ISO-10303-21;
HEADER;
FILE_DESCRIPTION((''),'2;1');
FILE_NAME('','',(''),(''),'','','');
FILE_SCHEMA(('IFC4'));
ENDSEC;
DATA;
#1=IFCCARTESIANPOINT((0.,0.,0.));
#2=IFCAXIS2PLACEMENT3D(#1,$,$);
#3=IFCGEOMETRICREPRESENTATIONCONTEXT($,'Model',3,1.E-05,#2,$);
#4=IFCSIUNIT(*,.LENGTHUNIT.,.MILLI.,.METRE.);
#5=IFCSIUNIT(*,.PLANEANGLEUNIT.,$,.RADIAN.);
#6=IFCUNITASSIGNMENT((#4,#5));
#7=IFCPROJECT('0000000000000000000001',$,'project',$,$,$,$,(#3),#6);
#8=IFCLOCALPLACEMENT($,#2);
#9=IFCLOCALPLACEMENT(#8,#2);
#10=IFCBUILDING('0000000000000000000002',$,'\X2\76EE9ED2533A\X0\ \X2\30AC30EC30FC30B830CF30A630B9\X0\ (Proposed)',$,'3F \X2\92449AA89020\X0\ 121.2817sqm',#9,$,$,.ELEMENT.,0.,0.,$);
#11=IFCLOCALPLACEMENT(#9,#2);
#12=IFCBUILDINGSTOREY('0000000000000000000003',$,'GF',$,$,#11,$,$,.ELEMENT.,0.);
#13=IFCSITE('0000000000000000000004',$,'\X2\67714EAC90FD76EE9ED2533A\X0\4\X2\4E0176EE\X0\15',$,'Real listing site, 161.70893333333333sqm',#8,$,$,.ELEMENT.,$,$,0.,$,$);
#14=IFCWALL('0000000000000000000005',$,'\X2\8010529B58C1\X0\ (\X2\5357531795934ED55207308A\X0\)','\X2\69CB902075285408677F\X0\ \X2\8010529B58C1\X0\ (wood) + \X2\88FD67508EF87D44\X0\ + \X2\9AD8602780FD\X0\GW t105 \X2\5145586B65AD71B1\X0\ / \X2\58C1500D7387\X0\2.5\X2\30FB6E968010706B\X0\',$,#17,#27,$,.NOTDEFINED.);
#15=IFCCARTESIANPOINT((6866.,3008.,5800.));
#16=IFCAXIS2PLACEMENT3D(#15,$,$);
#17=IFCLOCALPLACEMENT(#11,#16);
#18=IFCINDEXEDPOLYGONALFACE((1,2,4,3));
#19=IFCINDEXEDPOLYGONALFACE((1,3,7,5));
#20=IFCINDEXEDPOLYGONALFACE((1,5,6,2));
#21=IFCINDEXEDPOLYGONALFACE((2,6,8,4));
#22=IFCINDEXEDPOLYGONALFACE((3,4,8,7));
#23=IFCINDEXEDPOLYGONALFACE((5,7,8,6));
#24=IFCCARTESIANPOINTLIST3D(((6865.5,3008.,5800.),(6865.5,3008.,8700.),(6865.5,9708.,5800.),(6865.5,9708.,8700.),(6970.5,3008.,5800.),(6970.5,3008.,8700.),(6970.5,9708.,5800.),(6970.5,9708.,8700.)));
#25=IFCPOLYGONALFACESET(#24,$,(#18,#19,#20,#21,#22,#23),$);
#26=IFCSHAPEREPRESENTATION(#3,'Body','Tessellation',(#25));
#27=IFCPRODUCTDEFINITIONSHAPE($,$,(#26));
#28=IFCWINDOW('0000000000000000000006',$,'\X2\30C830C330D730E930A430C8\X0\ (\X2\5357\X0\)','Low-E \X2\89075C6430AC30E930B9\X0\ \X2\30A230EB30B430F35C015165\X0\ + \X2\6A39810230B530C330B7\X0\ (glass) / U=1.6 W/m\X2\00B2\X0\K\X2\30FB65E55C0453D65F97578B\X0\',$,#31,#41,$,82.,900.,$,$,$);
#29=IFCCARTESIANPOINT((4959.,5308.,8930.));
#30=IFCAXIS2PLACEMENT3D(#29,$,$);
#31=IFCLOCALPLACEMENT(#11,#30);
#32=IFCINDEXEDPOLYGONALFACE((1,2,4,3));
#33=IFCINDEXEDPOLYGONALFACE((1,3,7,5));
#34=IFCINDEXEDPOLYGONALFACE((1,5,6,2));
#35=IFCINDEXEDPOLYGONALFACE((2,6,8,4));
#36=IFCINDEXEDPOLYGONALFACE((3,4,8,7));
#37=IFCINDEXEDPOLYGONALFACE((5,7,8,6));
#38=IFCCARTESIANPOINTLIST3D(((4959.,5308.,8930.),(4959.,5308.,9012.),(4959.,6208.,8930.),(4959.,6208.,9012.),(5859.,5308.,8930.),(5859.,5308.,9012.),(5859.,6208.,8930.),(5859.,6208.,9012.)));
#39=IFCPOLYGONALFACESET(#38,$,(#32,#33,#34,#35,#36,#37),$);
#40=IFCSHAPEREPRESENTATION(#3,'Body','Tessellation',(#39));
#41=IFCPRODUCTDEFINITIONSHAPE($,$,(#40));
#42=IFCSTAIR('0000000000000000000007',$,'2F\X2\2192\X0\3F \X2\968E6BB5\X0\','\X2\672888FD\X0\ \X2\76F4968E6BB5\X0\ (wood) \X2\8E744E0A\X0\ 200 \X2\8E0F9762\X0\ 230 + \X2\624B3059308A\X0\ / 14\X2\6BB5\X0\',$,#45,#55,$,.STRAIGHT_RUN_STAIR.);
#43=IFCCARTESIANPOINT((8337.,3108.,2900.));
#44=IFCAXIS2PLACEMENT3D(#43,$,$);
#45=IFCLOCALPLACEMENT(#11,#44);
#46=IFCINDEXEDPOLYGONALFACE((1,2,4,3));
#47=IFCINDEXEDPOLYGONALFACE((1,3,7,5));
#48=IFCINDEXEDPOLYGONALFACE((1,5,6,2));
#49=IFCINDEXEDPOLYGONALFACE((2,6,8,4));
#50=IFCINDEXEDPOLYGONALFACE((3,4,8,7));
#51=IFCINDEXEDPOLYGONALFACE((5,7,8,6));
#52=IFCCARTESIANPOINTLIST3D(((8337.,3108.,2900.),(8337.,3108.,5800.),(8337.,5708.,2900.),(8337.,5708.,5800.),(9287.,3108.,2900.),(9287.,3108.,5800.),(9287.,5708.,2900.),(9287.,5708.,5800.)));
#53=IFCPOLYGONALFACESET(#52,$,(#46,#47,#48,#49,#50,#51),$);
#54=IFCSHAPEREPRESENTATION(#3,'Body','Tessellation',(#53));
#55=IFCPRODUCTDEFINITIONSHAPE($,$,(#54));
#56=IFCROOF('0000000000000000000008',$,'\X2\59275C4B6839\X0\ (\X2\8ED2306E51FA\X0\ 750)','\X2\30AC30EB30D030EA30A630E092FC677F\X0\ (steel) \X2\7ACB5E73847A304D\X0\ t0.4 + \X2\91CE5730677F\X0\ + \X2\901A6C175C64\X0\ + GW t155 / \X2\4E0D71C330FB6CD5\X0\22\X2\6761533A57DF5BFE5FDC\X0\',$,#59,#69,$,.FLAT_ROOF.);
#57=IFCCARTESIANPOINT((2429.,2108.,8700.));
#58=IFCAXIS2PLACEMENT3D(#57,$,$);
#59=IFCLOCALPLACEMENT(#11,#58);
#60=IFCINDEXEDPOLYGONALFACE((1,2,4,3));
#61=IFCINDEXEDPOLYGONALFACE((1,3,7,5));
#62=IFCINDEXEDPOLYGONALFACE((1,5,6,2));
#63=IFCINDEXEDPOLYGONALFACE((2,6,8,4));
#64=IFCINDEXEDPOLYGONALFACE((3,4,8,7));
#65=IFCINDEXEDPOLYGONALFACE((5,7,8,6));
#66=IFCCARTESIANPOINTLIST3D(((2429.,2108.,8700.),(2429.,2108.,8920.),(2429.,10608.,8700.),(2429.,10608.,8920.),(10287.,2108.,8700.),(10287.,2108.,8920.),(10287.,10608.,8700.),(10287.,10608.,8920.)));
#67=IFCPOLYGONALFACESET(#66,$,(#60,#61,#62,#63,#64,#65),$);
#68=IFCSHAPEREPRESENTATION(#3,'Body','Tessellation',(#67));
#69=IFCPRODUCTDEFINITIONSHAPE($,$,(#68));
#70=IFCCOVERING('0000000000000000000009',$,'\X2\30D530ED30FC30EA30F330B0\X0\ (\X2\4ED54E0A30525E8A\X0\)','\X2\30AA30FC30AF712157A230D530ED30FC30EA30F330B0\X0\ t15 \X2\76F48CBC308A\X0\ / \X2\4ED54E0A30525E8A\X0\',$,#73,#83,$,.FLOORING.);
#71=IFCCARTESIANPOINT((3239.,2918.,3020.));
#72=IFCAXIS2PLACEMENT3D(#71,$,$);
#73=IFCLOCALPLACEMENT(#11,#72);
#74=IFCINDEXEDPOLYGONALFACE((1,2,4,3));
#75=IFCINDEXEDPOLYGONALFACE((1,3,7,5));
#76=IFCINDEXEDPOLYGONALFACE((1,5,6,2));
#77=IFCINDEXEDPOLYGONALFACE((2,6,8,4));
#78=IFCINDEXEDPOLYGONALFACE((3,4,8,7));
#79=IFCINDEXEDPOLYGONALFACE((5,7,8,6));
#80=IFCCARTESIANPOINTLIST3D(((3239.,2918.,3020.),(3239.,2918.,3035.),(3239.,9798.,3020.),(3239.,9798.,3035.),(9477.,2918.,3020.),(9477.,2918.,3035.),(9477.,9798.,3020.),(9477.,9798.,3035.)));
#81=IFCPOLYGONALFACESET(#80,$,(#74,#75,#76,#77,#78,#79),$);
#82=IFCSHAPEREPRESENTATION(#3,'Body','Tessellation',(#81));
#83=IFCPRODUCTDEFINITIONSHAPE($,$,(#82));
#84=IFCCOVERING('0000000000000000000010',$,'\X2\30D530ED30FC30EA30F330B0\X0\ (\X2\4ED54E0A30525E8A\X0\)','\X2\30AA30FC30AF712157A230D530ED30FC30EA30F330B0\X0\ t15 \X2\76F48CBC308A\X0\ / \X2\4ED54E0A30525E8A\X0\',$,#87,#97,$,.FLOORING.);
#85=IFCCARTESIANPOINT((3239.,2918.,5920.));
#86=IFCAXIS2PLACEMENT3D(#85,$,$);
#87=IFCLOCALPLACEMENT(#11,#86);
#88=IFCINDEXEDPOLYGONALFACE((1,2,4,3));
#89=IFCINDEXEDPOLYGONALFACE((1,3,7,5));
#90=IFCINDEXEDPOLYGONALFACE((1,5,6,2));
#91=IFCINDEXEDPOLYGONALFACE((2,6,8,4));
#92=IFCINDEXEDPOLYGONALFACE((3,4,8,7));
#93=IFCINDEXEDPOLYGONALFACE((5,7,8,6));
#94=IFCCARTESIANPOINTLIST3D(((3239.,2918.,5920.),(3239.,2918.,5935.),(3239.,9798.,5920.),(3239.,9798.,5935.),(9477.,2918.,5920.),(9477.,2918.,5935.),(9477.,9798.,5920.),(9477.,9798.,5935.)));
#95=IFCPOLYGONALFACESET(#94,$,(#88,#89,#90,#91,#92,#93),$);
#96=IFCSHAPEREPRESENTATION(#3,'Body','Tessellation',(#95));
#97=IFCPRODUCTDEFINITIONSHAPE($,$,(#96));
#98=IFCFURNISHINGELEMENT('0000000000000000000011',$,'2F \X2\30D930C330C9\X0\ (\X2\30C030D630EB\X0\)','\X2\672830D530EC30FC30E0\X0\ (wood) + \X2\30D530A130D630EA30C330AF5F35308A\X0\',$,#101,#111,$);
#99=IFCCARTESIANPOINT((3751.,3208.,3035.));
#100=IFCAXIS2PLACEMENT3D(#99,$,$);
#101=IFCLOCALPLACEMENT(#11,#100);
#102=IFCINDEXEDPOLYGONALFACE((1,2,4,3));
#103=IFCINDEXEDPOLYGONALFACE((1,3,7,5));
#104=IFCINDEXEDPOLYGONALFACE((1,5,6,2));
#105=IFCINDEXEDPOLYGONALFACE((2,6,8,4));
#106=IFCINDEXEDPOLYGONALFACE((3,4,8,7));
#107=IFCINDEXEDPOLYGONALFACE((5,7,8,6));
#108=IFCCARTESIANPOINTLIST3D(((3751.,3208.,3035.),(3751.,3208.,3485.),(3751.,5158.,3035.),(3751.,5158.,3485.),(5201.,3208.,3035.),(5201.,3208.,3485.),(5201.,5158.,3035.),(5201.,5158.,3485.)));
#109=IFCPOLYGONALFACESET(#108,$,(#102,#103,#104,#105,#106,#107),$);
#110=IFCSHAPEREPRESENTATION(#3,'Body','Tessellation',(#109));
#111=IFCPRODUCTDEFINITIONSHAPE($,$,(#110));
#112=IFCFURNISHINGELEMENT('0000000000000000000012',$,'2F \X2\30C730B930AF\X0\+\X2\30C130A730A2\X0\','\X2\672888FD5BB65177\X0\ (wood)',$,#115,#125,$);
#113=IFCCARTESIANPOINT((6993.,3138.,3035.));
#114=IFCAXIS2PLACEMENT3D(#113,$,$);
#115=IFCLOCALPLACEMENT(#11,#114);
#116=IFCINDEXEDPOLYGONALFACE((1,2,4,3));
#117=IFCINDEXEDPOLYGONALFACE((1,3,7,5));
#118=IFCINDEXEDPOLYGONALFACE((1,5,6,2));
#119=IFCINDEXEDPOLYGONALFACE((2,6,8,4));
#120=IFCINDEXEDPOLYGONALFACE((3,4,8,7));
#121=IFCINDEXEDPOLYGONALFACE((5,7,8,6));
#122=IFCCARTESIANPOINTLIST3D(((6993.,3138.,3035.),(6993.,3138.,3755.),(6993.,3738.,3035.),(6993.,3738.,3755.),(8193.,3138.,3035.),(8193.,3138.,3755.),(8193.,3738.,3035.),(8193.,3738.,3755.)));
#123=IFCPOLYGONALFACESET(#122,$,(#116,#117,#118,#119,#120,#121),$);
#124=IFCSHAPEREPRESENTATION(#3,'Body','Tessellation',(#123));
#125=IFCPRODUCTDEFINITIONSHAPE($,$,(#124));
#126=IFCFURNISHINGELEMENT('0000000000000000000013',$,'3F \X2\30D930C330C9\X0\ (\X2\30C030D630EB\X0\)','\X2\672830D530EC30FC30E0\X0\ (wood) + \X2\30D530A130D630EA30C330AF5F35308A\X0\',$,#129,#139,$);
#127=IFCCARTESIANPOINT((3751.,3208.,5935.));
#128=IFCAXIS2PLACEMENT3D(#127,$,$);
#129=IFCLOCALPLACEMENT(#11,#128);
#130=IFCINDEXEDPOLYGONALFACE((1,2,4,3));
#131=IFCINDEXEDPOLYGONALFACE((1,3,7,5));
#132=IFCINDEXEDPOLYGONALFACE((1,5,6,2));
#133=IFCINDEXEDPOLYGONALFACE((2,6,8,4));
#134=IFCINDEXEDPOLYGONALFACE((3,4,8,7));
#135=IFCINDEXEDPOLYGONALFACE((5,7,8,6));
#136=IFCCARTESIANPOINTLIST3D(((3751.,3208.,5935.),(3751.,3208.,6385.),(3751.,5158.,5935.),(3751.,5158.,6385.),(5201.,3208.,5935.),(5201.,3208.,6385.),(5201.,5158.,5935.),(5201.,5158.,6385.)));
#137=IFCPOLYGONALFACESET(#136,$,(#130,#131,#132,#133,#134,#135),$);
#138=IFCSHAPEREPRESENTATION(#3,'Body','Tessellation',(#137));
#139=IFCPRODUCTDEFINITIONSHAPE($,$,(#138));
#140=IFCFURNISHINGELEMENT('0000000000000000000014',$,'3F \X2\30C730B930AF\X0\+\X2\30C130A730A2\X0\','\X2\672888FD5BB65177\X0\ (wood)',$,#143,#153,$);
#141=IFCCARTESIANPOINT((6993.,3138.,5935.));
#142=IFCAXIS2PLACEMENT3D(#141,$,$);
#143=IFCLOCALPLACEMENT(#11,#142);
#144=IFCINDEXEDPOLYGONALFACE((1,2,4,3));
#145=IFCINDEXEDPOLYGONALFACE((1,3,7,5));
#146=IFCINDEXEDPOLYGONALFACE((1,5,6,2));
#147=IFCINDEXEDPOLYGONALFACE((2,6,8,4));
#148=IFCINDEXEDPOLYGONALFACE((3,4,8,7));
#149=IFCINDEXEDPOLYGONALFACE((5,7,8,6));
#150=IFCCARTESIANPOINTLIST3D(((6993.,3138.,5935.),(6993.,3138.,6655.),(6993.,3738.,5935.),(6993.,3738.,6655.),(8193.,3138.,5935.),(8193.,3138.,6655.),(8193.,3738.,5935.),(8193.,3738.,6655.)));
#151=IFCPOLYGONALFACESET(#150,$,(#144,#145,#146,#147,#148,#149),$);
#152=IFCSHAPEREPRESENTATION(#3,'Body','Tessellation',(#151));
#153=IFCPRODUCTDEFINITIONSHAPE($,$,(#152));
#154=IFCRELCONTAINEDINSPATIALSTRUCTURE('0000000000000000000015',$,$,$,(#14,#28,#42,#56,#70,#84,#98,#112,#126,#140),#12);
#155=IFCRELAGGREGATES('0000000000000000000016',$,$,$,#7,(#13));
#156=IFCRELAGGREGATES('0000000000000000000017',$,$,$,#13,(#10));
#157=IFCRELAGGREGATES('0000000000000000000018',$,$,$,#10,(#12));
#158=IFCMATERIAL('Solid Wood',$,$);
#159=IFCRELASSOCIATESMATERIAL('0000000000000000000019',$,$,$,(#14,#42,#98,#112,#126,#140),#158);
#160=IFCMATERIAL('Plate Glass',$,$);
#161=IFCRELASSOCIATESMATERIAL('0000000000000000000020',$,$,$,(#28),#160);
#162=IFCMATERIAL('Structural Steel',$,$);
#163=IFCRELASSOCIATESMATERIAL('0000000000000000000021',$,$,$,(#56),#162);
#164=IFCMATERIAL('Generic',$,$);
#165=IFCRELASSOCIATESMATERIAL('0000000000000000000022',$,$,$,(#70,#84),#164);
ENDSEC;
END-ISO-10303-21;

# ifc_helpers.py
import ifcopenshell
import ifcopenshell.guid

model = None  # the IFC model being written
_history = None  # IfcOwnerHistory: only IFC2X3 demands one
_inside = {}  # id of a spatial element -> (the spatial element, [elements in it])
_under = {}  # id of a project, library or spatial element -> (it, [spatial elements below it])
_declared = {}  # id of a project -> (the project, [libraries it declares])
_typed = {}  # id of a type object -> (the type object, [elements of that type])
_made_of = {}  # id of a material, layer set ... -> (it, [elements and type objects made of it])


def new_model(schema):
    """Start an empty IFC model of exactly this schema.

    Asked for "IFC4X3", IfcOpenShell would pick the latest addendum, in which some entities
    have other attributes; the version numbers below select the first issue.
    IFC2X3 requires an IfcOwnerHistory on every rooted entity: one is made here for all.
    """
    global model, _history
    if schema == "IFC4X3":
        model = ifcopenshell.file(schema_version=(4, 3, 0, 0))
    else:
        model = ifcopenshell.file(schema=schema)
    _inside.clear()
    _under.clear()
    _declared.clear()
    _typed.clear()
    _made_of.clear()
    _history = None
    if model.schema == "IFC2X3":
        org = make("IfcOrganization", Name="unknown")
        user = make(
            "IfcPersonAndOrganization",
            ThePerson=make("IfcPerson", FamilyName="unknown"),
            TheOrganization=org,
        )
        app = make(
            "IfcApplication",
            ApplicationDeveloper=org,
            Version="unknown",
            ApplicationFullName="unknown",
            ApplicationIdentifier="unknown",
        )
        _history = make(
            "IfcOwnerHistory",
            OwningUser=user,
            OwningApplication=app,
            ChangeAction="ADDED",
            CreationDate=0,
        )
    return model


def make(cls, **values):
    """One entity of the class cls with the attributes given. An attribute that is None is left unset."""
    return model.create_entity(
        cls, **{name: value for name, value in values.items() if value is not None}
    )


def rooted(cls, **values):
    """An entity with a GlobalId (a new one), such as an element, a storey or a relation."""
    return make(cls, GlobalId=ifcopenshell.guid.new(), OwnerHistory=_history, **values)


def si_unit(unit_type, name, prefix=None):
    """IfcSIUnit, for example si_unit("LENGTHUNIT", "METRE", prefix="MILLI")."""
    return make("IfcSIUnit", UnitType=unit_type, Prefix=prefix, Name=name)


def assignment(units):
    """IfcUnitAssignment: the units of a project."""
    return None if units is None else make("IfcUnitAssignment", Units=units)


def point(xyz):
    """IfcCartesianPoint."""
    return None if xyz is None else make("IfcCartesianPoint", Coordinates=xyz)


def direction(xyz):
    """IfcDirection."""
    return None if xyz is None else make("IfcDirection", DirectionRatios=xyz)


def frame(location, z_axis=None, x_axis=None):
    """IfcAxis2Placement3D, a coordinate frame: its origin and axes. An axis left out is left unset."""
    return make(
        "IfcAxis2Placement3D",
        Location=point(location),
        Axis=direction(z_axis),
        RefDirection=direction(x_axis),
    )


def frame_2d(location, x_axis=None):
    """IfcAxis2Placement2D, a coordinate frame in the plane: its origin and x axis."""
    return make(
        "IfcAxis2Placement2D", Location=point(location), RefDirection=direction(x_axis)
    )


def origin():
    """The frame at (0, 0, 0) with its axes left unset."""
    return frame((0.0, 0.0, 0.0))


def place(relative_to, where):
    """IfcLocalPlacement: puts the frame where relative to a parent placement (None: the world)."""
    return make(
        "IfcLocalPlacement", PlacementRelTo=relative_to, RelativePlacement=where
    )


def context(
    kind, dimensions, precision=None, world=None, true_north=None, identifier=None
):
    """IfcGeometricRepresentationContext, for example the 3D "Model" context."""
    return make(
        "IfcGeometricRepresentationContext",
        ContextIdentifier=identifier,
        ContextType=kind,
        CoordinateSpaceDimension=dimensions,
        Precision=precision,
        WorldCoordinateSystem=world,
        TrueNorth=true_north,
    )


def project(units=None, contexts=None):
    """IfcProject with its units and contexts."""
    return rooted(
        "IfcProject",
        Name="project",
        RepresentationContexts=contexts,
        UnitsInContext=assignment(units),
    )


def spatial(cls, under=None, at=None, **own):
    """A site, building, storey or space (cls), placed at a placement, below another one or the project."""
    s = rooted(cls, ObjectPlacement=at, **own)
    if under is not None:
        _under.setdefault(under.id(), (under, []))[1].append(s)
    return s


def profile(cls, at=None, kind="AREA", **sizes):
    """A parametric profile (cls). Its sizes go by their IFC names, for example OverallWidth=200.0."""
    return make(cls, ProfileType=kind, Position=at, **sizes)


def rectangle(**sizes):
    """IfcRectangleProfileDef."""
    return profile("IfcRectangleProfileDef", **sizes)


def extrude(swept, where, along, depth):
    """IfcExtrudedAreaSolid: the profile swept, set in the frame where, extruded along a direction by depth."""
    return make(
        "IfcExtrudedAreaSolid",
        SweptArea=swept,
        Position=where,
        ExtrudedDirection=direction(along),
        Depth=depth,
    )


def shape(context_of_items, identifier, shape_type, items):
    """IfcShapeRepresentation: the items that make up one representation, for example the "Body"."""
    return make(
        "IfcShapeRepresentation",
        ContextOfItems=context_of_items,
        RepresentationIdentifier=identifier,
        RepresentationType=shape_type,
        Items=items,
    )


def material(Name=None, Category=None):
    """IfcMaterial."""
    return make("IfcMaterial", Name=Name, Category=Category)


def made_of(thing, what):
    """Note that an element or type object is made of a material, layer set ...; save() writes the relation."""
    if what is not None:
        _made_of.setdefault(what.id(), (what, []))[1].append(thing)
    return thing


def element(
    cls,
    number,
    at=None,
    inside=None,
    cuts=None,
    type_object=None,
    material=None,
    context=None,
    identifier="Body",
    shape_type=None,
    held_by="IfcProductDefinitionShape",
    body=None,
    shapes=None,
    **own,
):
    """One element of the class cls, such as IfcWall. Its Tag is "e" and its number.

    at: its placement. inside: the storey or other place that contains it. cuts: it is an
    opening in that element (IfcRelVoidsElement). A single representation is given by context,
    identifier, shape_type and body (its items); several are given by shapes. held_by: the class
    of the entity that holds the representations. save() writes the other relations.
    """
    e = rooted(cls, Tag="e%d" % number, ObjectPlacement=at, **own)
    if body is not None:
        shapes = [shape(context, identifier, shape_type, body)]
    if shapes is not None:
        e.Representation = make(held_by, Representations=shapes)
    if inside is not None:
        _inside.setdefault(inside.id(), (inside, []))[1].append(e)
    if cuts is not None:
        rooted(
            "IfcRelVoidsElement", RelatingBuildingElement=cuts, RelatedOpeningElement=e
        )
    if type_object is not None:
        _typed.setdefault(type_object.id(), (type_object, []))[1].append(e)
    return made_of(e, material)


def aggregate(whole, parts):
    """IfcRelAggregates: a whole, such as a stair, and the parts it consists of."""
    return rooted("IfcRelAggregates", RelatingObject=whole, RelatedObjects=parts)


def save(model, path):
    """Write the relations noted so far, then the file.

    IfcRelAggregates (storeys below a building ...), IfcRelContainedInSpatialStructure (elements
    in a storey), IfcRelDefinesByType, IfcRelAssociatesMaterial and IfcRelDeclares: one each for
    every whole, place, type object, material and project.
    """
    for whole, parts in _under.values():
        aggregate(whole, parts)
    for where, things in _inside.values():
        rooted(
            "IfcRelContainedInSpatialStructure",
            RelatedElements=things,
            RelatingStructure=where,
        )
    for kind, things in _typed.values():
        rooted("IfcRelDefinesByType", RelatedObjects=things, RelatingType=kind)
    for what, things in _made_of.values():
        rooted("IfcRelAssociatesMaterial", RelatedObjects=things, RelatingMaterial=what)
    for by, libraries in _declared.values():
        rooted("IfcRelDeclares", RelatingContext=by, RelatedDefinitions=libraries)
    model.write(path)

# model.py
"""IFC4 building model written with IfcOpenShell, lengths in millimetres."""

from ifc_helpers import new_model, si_unit, frame, frame_2d, origin, place, context, project, spatial, rectangle, extrude, material, element, save


model = new_model("IFC4")

# Units and contexts
model_context = context("Model", 3, precision=1e-05, world=origin())
ifc_project = project(units=[si_unit("LENGTHUNIT", "METRE", prefix="MILLI"), si_unit("PLANEANGLEUNIT", "RADIAN")], contexts=[model_context])

# Site, building, storey
site_placement = place(None, origin())
site = spatial("IfcSite", under=ifc_project, at=site_placement, Name="東京都目黒区4丁目15", ObjectType="Real listing site, 161.70893333333333sqm", CompositionType="ELEMENT", RefElevation=0.0)
building_placement = place(site_placement, origin())
building = spatial("IfcBuilding", under=site, at=building_placement, Name="目黒区 ガレージハウス (Proposed)", ObjectType="3F 鉄骨造 121.2817sqm", CompositionType="ELEMENT", ElevationOfRefHeight=0.0, ElevationOfTerrain=0.0)
storey_placement = place(building_placement, origin())
storey = spatial("IfcBuildingStorey", under=building, at=storey_placement, Name="GF", CompositionType="ELEMENT", Elevation=0.0)

# Shared definitions
ifc_material_1 = material(Name="Solid Wood")

# Shared definitions
ifc_material_2 = material(Name="Plate Glass")

# Wall
wall_1_placement = place(storey_placement, frame((6866.0, 3008.0, 5800.0)))
element("IfcWall", 1, at=wall_1_placement, inside=storey, material=ifc_material_1, Name="耐力壁 (南北間仕切り)", Description="構造用合板 耐力壁 (wood) + 製材軸組 + 高性能GW t105 充填断熱 / 壁倍率2.5・準耐火", PredefinedType="NOTDEFINED", context=model_context, shape_type="SweptSolid", body=[
    extrude(rectangle(XDim=105.0, YDim=6700.0, at=frame_2d((52.0, 3350.0))), frame((6866.0, 3008.0, 5800.0)), (0.0, 0.0, 1.0), 2900.0),
])

# Window
window_1_placement = place(storey_placement, frame((4959.0, 5308.0, 8930.0)))
element("IfcWindow", 2, at=window_1_placement, inside=storey, material=ifc_material_2, Name="トップライト (南)", Description="Low-E 複層ガラス アルゴン封入 + 樹脂サッシ (glass) / U=1.6 W/m²K・日射取得型", OverallHeight=82.0, OverallWidth=900.0, context=model_context, shape_type="SweptSolid", body=[
    extrude(rectangle(XDim=900.0, YDim=900.0, at=frame_2d((450.0, 450.0))), frame((4959.0, 5308.0, 8930.0)), (0.0, 0.0, 1.0), 82.0),
])

# Stair
stair_placement = place(storey_placement, frame((8337.0, 3108.0, 2900.0)))
element("IfcStair", 3, at=stair_placement, inside=storey, material=ifc_material_1, Name="2F→3F 階段", Description="木製 直階段 (wood) 蹴上 200 踏面 230 + 手すり / 14段", PredefinedType="STRAIGHT_RUN_STAIR", context=model_context, shape_type="SweptSolid", body=[
    extrude(rectangle(XDim=950.0, YDim=2600.0, at=frame_2d((475.0, 1300.0))), frame((8337.0, 3108.0, 2900.0)), (0.0, 0.0, 1.0), 2900.0),
])

# Roof
ifc_material_3 = material(Name="Structural Steel")
roof_placement = place(storey_placement, frame((2429.0, 2108.0, 8700.0)))
element("IfcRoof", 4, at=roof_placement, inside=storey, material=ifc_material_3, Name="大屋根 (軒の出 750)", Description="ガルバリウム鋼板 (steel) 立平葺き t0.4 + 野地板 + 通気層 + GW t155 / 不燃・法22条区域対応", PredefinedType="FLAT_ROOF", context=model_context, shape_type="SweptSolid", body=[
    extrude(rectangle(XDim=7858.0, YDim=8500.0, at=frame_2d((3929.0, 4250.0))), frame((2429.0, 2108.0, 8700.0)), (0.0, 0.0, 1.0), 220.0),
])

# Coverings
ifc_material_4 = material(Name="Generic")
covering_1_placement = place(storey_placement, frame((3239.0, 2918.0, 3020.0)))
element("IfcCovering", 5, at=covering_1_placement, inside=storey, material=ifc_material_4, Name="フローリング (仕上げ床)", Description="オーク無垢フローリング t15 直貼り / 仕上げ床", PredefinedType="FLOORING", context=model_context, shape_type="SweptSolid", body=[
    extrude(rectangle(XDim=6238.0, YDim=6880.0, at=frame_2d((3119.0, 3440.0))), frame((3239.0, 2918.0, 3020.0)), (0.0, 0.0, 1.0), 15.0),
])
covering_2_placement = place(storey_placement, frame((3239.0, 2918.0, 5920.0)))
element("IfcCovering", 6, at=covering_2_placement, inside=storey, material=ifc_material_4, Name="フローリング (仕上げ床)", Description="オーク無垢フローリング t15 直貼り / 仕上げ床", PredefinedType="FLOORING", context=model_context, shape_type="SweptSolid", body=[
    extrude(rectangle(XDim=6238.0, YDim=6880.0, at=frame_2d((3119.0, 3440.0))), frame((3239.0, 2918.0, 5920.0)), (0.0, 0.0, 1.0), 15.0),
])

# Furnishing elements
furnishing_1_placement = place(storey_placement, frame((3751.0, 3208.0, 3035.0)))
element("IfcFurnishingElement", 7, at=furnishing_1_placement, inside=storey, material=ifc_material_1, Name="2F ベッド (ダブル)", Description="木フレーム (wood) + ファブリック張り", context=model_context, shape_type="SweptSolid", body=[
    extrude(rectangle(XDim=1450.0, YDim=1950.0, at=frame_2d((725.0, 975.0))), frame((3751.0, 3208.0, 3035.0)), (0.0, 0.0, 1.0), 450.0),
])
furnishing_2_placement = place(storey_placement, frame((6993.0, 3138.0, 3035.0)))
element("IfcFurnishingElement", 8, at=furnishing_2_placement, inside=storey, material=ifc_material_1, Name="2F デスク+チェア", Description="木製家具 (wood)", context=model_context, shape_type="SweptSolid", body=[
    extrude(rectangle(XDim=1200.0, YDim=600.0, at=frame_2d((600.0, 300.0))), frame((6993.0, 3138.0, 3035.0)), (0.0, 0.0, 1.0), 720.0),
])
furnishing_3_placement = place(storey_placement, frame((3751.0, 3208.0, 5935.0)))
element("IfcFurnishingElement", 9, at=furnishing_3_placement, inside=storey, material=ifc_material_1, Name="3F ベッド (ダブル)", Description="木フレーム (wood) + ファブリック張り", context=model_context, shape_type="SweptSolid", body=[
    extrude(rectangle(XDim=1450.0, YDim=1950.0, at=frame_2d((725.0, 975.0))), frame((3751.0, 3208.0, 5935.0)), (0.0, 0.0, 1.0), 450.0),
])
furnishing_4_placement = place(storey_placement, frame((6993.0, 3138.0, 5935.0)))
element("IfcFurnishingElement", 10, at=furnishing_4_placement, inside=storey, material=ifc_material_1, Name="3F デスク+チェア", Description="木製家具 (wood)", context=model_context, shape_type="SweptSolid", body=[
    extrude(rectangle(XDim=1200.0, YDim=600.0, at=frame_2d((600.0, 300.0))), frame((6993.0, 3138.0, 5935.0)), (0.0, 0.0, 1.0), 720.0),
])

save(model, "model.ifc")
